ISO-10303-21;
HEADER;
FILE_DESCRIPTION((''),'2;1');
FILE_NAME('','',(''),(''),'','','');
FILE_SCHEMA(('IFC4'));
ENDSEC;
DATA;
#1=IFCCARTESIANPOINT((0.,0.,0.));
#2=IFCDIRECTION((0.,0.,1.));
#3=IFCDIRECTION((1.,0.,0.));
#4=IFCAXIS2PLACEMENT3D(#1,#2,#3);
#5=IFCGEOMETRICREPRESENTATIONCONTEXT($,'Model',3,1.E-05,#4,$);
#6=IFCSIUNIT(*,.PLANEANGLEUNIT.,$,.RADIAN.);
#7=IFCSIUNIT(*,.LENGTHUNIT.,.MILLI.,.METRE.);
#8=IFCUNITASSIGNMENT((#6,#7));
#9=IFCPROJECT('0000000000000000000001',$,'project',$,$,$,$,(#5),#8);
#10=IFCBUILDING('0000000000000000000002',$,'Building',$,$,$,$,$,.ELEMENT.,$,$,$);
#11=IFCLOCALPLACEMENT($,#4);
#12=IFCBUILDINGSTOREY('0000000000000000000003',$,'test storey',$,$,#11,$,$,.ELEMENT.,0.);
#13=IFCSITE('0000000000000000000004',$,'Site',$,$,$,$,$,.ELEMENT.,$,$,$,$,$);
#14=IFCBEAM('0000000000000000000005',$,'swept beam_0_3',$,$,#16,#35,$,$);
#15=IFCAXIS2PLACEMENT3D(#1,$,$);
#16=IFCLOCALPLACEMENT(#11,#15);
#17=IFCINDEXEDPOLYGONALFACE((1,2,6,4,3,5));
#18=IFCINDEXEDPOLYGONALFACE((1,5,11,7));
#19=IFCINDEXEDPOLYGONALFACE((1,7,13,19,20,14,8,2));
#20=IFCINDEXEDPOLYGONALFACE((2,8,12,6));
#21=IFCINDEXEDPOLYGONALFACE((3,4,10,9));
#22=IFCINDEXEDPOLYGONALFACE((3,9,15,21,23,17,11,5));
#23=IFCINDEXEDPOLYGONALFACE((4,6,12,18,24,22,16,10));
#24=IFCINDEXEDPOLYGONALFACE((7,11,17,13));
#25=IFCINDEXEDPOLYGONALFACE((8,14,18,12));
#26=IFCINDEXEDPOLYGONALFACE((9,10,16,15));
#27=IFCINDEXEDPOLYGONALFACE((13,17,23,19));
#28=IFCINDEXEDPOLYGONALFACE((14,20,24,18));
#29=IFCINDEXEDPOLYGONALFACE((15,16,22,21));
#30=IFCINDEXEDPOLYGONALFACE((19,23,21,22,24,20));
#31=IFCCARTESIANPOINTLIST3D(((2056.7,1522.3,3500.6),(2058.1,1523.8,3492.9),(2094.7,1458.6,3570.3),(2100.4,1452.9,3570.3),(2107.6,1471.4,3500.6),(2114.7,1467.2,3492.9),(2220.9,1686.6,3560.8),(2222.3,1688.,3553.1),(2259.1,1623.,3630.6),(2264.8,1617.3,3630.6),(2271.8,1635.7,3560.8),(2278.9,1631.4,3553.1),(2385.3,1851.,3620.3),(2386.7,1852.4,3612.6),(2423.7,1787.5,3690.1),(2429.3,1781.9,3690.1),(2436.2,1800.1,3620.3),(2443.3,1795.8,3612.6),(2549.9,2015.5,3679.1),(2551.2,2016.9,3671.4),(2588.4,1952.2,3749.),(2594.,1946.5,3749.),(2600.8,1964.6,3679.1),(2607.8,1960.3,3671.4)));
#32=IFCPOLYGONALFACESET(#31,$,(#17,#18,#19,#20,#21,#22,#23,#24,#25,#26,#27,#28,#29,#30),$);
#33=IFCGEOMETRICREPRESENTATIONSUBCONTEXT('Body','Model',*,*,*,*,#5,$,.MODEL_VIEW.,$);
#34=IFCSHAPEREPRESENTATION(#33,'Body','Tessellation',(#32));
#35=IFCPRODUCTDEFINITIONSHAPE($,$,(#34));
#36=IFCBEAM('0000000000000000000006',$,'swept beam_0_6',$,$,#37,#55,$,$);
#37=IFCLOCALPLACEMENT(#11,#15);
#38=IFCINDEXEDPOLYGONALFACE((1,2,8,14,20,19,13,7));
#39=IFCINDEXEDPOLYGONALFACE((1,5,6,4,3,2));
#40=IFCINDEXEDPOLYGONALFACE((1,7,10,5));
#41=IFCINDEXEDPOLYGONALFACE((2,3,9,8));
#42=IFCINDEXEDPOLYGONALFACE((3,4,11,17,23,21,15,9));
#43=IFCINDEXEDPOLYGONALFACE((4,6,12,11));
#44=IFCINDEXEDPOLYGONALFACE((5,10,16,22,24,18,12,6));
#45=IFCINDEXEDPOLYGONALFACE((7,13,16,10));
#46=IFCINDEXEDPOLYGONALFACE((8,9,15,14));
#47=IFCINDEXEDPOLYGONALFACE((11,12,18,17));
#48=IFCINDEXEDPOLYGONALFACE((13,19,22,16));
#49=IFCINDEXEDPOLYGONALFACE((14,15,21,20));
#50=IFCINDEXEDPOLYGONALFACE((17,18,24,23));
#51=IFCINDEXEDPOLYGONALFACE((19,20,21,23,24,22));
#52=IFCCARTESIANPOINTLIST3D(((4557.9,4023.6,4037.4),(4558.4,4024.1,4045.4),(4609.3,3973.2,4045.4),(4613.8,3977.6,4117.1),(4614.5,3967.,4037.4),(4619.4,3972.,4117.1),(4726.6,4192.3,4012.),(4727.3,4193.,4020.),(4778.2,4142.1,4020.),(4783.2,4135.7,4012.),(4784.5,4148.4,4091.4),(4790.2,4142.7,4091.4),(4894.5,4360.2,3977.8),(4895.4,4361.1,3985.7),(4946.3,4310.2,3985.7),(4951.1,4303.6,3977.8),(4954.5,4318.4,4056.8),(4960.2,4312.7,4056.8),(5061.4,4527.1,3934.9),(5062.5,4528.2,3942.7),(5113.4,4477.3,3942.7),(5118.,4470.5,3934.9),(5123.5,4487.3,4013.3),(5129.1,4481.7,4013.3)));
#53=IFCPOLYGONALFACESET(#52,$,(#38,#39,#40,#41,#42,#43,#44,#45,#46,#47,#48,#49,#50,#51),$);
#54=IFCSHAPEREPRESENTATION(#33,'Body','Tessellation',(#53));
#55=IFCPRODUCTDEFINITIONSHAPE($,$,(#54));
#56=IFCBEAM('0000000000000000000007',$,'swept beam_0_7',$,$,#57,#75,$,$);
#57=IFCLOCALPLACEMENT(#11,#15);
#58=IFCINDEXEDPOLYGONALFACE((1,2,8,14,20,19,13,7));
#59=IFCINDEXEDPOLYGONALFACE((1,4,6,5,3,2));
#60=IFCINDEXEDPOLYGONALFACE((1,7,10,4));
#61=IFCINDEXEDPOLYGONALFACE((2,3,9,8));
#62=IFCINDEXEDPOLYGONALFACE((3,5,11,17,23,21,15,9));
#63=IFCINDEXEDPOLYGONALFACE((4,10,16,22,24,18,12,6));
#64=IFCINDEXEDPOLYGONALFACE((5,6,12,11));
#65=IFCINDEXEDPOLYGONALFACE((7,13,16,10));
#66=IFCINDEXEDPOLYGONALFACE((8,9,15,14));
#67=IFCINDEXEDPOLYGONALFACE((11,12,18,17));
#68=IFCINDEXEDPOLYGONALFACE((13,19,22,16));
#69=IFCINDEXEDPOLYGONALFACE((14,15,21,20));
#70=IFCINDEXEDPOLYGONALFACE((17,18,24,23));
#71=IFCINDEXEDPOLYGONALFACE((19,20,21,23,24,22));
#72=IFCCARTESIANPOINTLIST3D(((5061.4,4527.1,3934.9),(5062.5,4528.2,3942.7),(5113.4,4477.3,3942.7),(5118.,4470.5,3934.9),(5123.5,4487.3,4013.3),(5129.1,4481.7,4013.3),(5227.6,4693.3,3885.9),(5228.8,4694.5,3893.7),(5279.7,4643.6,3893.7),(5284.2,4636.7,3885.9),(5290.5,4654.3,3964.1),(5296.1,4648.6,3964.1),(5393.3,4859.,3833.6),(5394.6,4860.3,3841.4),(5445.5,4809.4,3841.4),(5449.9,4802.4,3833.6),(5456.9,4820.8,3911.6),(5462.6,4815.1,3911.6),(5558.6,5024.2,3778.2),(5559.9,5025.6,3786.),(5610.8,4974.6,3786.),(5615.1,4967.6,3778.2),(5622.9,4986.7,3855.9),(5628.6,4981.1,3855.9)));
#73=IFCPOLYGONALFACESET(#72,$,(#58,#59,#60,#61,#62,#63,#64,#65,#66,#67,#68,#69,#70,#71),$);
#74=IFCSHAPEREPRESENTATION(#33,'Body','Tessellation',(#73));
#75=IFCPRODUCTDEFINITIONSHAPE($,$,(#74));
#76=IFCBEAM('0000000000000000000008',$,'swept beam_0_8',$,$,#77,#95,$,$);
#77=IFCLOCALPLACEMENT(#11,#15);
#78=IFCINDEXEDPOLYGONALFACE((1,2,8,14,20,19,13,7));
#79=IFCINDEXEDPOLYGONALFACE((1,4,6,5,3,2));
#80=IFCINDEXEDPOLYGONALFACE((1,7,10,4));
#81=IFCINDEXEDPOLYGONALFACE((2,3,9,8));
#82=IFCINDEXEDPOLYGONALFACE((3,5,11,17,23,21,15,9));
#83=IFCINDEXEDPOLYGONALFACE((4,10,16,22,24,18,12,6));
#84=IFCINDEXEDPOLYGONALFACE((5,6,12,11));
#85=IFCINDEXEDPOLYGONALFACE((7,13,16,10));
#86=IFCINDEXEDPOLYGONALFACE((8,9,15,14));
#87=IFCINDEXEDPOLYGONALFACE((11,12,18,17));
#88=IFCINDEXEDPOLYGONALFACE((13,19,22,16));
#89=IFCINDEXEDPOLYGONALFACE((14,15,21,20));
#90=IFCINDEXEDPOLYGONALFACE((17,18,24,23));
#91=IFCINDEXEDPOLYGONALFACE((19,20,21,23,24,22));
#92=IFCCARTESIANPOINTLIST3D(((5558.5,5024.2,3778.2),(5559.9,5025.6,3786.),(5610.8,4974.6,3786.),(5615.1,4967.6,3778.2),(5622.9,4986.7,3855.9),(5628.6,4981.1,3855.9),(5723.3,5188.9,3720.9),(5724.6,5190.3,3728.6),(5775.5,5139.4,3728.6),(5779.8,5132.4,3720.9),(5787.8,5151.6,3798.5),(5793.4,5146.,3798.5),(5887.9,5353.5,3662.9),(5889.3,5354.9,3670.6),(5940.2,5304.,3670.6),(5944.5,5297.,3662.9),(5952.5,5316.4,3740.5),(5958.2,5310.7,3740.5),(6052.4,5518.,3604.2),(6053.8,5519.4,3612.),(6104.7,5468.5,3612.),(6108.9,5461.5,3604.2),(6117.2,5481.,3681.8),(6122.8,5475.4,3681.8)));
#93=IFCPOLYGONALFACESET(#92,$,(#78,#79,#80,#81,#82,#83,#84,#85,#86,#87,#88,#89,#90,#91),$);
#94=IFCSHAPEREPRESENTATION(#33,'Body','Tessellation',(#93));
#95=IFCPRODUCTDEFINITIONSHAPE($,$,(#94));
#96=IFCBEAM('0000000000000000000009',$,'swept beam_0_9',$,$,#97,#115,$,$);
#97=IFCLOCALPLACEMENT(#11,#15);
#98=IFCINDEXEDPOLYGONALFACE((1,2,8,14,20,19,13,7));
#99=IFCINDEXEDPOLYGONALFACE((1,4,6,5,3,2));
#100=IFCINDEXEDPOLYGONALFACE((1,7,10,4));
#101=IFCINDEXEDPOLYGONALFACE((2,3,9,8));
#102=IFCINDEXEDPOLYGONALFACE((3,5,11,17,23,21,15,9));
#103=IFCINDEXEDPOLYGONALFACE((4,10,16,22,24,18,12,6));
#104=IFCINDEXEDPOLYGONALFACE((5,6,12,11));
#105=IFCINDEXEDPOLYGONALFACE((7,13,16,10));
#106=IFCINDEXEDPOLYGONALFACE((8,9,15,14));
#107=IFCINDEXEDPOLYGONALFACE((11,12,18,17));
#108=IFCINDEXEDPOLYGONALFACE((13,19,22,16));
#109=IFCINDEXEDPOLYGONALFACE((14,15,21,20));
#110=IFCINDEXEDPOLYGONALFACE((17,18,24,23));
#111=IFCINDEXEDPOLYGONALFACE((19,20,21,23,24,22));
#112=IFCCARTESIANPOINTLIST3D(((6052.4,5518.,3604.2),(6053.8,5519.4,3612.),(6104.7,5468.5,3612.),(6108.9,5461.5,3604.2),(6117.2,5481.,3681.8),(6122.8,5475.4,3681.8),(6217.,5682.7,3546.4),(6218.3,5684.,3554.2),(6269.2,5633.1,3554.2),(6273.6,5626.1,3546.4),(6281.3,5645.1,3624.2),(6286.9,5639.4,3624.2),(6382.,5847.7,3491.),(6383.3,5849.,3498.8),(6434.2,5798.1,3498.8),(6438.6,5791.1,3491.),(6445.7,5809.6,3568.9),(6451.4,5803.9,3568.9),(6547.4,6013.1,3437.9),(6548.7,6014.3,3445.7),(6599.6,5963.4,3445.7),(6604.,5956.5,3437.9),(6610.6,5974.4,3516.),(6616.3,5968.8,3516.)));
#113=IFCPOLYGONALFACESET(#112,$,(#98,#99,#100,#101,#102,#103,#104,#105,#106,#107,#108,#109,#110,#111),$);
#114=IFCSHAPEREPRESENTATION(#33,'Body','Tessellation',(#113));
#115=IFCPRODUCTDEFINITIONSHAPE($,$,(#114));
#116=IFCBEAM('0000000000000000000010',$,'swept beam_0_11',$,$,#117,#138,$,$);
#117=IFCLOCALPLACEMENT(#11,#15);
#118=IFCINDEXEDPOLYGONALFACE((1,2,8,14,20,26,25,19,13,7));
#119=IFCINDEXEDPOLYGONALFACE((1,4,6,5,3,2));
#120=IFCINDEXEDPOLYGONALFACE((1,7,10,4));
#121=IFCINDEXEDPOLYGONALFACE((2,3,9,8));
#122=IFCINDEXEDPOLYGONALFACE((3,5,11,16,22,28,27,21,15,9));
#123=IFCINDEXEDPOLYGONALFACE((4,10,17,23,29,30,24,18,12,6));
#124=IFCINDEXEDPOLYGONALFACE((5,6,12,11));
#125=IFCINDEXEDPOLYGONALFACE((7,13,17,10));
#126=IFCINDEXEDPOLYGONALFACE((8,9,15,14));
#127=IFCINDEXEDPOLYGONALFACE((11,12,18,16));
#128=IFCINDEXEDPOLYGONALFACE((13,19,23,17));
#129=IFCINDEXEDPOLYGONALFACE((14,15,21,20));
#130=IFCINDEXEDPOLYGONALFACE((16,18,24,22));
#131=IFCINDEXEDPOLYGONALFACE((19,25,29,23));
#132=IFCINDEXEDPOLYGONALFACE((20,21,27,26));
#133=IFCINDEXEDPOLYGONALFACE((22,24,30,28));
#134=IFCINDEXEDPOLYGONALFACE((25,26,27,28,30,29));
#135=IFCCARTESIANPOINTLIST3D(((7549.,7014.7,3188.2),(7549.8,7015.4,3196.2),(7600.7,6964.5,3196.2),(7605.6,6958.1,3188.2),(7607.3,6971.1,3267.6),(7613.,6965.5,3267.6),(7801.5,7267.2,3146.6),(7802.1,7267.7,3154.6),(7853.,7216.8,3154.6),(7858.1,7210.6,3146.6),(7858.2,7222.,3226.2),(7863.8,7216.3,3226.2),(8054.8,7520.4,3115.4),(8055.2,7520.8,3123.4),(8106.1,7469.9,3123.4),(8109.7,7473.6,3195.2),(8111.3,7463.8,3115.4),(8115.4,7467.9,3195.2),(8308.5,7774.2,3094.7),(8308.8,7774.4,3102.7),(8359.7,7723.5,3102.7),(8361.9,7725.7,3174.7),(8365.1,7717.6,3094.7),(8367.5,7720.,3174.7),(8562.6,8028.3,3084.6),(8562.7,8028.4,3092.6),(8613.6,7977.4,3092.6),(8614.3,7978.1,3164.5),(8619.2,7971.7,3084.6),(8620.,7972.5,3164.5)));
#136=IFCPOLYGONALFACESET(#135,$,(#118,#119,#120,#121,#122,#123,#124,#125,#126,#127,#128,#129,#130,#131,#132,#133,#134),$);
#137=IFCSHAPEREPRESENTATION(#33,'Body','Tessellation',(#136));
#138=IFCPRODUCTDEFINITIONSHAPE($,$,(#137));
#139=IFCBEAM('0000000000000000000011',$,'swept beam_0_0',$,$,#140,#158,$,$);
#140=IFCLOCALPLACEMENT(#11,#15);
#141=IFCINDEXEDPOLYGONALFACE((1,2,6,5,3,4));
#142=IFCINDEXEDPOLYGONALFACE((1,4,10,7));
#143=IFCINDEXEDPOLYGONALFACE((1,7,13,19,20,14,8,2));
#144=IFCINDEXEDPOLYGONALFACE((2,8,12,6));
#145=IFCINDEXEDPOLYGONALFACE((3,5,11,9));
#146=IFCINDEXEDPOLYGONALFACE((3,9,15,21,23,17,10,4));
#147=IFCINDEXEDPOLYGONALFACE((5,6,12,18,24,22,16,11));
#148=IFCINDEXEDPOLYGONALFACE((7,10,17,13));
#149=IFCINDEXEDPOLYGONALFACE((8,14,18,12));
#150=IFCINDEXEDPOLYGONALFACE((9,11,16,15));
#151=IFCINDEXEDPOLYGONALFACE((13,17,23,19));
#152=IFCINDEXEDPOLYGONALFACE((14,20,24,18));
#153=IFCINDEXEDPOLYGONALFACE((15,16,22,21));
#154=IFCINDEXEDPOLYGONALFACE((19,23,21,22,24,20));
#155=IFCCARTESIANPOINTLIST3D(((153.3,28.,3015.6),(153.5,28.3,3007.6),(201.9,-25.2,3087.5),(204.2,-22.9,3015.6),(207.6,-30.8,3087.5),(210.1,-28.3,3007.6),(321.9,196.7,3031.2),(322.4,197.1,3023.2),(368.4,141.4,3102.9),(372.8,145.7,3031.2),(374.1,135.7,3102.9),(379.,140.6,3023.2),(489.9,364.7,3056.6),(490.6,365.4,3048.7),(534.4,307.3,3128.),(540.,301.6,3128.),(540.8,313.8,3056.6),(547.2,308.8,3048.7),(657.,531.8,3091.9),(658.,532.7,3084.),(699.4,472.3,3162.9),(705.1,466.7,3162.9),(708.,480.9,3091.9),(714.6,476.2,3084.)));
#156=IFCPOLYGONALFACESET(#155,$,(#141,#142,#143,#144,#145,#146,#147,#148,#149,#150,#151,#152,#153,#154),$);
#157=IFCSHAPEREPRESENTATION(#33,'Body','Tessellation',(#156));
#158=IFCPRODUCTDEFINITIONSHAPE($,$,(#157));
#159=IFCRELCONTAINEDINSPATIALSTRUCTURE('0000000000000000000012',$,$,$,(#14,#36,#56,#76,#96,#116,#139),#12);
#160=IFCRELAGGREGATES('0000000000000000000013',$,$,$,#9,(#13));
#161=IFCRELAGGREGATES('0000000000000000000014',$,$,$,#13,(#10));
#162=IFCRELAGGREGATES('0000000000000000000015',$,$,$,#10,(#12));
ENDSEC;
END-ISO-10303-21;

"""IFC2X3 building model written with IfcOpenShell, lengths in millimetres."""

from ifc_helpers import new_model, entity, si_unit, origin_with_axes, place, context, subcontext, project, spatial, element, save


model = new_model("IFC2X3")

# Units and contexts
model_context = context("Model", 3, precision=1e-05, world=origin_with_axes())
body_context = subcontext(model_context, "Body", "Model", "MODEL_VIEW")
ifc_project = project(units=[si_unit("PLANEANGLEUNIT", "RADIAN"), si_unit("LENGTHUNIT", "METRE", prefix="MILLI")], contexts=[model_context])

# Site, building, storey
site = spatial("IfcSite", under=ifc_project, Name="Site", CompositionType="ELEMENT")
building = spatial("IfcBuilding", under=site, Name="Building", CompositionType="ELEMENT")
storey_placement = place(None, origin_with_axes())
storey = spatial("IfcBuildingStorey", under=building, at=storey_placement, Name="test storey", CompositionType="ELEMENT", Elevation=0.0)

# Beams
beam_1_placement = place(storey_placement, origin_with_axes())
element("IfcBeam", 1, at=beam_1_placement, inside=storey, Name="swept beam_0_3", context=body_context, shape_type="SweptSolid", body=[
    entity("IfcRevolvedAreaSolid", entity("IfcArbitraryClosedProfileDef", "AREA", None, entity("IfcPolyline", [entity("IfcCartesianPoint", [80.0, -40.0]), entity("IfcCartesianPoint", [80.0, -32.0]), entity("IfcCartesianPoint", [8.0, -32.0]), entity("IfcCartesianPoint", [8.0, 40.0]), entity("IfcCartesianPoint", [0.0, 40.0]), entity("IfcCartesianPoint", [0.0, -40.0]), entity("IfcCartesianPoint", [80.0, -40.0])])), entity("IfcAxis2Placement3D", entity("IfcCartesianPoint", [2086.4, 1495.5, 3492.9]), entity("IfcDirection", [-0.6842, -0.6842, -0.2523]), entity("IfcDirection", [-0.1784, -0.1784, 0.9677])), entity("IfcAxis1Placement", entity("IfcCartesianPoint", [-79650.6, 0.0, 0.0]), entity("IfcDirection", [0.0, 1.0, 0.0])), 0.009038),
])
beam_2_placement = place(storey_placement, origin_with_axes())
element("IfcBeam", 2, at=beam_2_placement, inside=storey, Name="swept beam_0_6", context=body_context, shape_type="SweptSolid", body=[
    entity("IfcRevolvedAreaSolid", entity("IfcArbitraryClosedProfileDef", "AREA", None, entity("IfcPolyline", [entity("IfcCartesianPoint", [80.0, -40.0]), entity("IfcCartesianPoint", [80.0, -32.0]), entity("IfcCartesianPoint", [8.0, -32.0]), entity("IfcCartesianPoint", [8.0, 40.0]), entity("IfcCartesianPoint", [0.0, 40.0]), entity("IfcCartesianPoint", [0.0, -40.0]), entity("IfcCartesianPoint", [80.0, -40.0])])), entity("IfcAxis2Placement3D", entity("IfcCartesianPoint", [4586.2, 3995.3, 4037.4]), entity("IfcDirection", [-0.7044, -0.7044, 0.0873]), entity("IfcDirection", [0.0617, 0.0617, 0.9962])), entity("IfcAxis1Placement", entity("IfcCartesianPoint", [-6473.2, 0.0, 0.0]), entity("IfcDirection", [0.0, 1.0, 0.0])), 0.111187),
])
beam_3_placement = place(storey_placement, origin_with_axes())
element("IfcBeam", 3, at=beam_3_placement, inside=storey, Name="swept beam_0_7", context=body_context, shape_type="SweptSolid", body=[
    entity("IfcRevolvedAreaSolid", entity("IfcArbitraryClosedProfileDef", "AREA", None, entity("IfcPolyline", [entity("IfcCartesianPoint", [80.0, -40.0]), entity("IfcCartesianPoint", [80.0, -32.0]), entity("IfcCartesianPoint", [8.0, -32.0]), entity("IfcCartesianPoint", [8.0, 40.0]), entity("IfcCartesianPoint", [0.0, 40.0]), entity("IfcCartesianPoint", [0.0, -40.0]), entity("IfcCartesianPoint", [80.0, -40.0])])), entity("IfcAxis2Placement3D", entity("IfcCartesianPoint", [5089.7, 4498.8, 3934.9]), entity("IfcDirection", [-0.6932, -0.6932, 0.1973]), entity("IfcDirection", [0.1395, 0.1395, 0.9803])), entity("IfcAxis1Placement", entity("IfcCartesianPoint", [-17455.8, 0.0, 0.0]), entity("IfcDirection", [0.0, 1.0, 0.0])), 0.041268),
])
beam_4_placement = place(storey_placement, origin_with_axes())
element("IfcBeam", 4, at=beam_4_placement, inside=storey, Name="swept beam_0_8", context=body_context, shape_type="SweptSolid", body=[
    entity("IfcRevolvedAreaSolid", entity("IfcArbitraryClosedProfileDef", "AREA", None, entity("IfcPolyline", [entity("IfcCartesianPoint", [80.0, -40.0]), entity("IfcCartesianPoint", [80.0, -32.0]), entity("IfcCartesianPoint", [8.0, -32.0]), entity("IfcCartesianPoint", [8.0, 40.0]), entity("IfcCartesianPoint", [0.0, 40.0]), entity("IfcCartesianPoint", [0.0, -40.0]), entity("IfcCartesianPoint", [80.0, -40.0])])), entity("IfcAxis2Placement3D", entity("IfcCartesianPoint", [5586.8, 4995.9, 3778.2]), entity("IfcDirection", [-0.6869, -0.6869, 0.2376]), entity("IfcDirection", [0.168, 0.168, 0.9714])), entity("IfcAxis1Placement", entity("IfcCartesianPoint", [-85319.4, 0.0, 0.0]), entity("IfcDirection", [0.0, 1.0, 0.0])), 0.008436),
])
beam_5_placement = place(storey_placement, origin_with_axes())
element("IfcBeam", 5, at=beam_5_placement, inside=storey, Name="swept beam_0_9", context=body_context, shape_type="SweptSolid", body=[
    entity("IfcRevolvedAreaSolid", entity("IfcArbitraryClosedProfileDef", "AREA", None, entity("IfcPolyline", [entity("IfcCartesianPoint", [-80.0, 40.0]), entity("IfcCartesianPoint", [-80.0, 32.0]), entity("IfcCartesianPoint", [-8.0, 32.0]), entity("IfcCartesianPoint", [-8.0, -40.0]), entity("IfcCartesianPoint", [0.0, -40.0]), entity("IfcCartesianPoint", [0.0, 40.0]), entity("IfcCartesianPoint", [-80.0, 40.0])])), entity("IfcAxis2Placement3D", entity("IfcCartesianPoint", [6080.7, 5489.7, 3604.2]), entity("IfcDirection", [-0.6854, -0.6854, 0.2458]), entity("IfcDirection", [-0.1738, -0.1738, -0.9693])), entity("IfcAxis1Placement", entity("IfcCartesianPoint", [-23942.5, 0.0, 0.0]), entity("IfcDirection", [0.0, 1.0, 0.0])), 0.030058),
])
beam_6_placement = place(storey_placement, origin_with_axes())
element("IfcBeam", 6, at=beam_6_placement, inside=storey, Name="swept beam_0_11", context=body_context, shape_type="SweptSolid", body=[
    entity("IfcRevolvedAreaSolid", entity("IfcArbitraryClosedProfileDef", "AREA", None, entity("IfcPolyline", [entity("IfcCartesianPoint", [-80.0, 40.0]), entity("IfcCartesianPoint", [-80.0, 32.0]), entity("IfcCartesianPoint", [-8.0, 32.0]), entity("IfcCartesianPoint", [-8.0, -40.0]), entity("IfcCartesianPoint", [0.0, -40.0]), entity("IfcCartesianPoint", [0.0, 40.0]), entity("IfcCartesianPoint", [-80.0, 40.0])])), entity("IfcAxis2Placement3D", entity("IfcCartesianPoint", [7577.3, 6986.4, 3188.2]), entity("IfcDirection", [-0.7011, -0.7011, 0.1303]), entity("IfcDirection", [-0.0921, -0.0921, -0.9915])), entity("IfcAxis1Placement", entity("IfcCartesianPoint", [-12299.4, 0.0, 0.0]), entity("IfcDirection", [0.0, 1.0, 0.0])), 0.116917),
])
beam_7_placement = place(storey_placement, origin_with_axes())
element("IfcBeam", 7, at=beam_7_placement, inside=storey, Name="swept beam_0_0", context=body_context, shape_type="SweptSolid", body=[
    entity("IfcRevolvedAreaSolid", entity("IfcArbitraryClosedProfileDef", "AREA", None, entity("IfcPolyline", [entity("IfcCartesianPoint", [-80.0, 40.0]), entity("IfcCartesianPoint", [-80.0, 32.0]), entity("IfcCartesianPoint", [-8.0, 32.0]), entity("IfcCartesianPoint", [-8.0, -40.0]), entity("IfcCartesianPoint", [0.0, -40.0]), entity("IfcCartesianPoint", [0.0, 40.0]), entity("IfcCartesianPoint", [-80.0, 40.0])])), entity("IfcAxis2Placement3D", entity("IfcCartesianPoint", [181.8, 0.0, 3007.6]), entity("IfcDirection", [-0.7064, -0.7064, -0.0446]), entity("IfcDirection", [0.0315, 0.0315, -0.999])), entity("IfcAxis1Placement", entity("IfcCartesianPoint", [-5780.2, 0.0, 0.0]), entity("IfcDirection", [0.0, 1.0, 0.0])), 0.12421),
])

save(model, "model.ifc")
